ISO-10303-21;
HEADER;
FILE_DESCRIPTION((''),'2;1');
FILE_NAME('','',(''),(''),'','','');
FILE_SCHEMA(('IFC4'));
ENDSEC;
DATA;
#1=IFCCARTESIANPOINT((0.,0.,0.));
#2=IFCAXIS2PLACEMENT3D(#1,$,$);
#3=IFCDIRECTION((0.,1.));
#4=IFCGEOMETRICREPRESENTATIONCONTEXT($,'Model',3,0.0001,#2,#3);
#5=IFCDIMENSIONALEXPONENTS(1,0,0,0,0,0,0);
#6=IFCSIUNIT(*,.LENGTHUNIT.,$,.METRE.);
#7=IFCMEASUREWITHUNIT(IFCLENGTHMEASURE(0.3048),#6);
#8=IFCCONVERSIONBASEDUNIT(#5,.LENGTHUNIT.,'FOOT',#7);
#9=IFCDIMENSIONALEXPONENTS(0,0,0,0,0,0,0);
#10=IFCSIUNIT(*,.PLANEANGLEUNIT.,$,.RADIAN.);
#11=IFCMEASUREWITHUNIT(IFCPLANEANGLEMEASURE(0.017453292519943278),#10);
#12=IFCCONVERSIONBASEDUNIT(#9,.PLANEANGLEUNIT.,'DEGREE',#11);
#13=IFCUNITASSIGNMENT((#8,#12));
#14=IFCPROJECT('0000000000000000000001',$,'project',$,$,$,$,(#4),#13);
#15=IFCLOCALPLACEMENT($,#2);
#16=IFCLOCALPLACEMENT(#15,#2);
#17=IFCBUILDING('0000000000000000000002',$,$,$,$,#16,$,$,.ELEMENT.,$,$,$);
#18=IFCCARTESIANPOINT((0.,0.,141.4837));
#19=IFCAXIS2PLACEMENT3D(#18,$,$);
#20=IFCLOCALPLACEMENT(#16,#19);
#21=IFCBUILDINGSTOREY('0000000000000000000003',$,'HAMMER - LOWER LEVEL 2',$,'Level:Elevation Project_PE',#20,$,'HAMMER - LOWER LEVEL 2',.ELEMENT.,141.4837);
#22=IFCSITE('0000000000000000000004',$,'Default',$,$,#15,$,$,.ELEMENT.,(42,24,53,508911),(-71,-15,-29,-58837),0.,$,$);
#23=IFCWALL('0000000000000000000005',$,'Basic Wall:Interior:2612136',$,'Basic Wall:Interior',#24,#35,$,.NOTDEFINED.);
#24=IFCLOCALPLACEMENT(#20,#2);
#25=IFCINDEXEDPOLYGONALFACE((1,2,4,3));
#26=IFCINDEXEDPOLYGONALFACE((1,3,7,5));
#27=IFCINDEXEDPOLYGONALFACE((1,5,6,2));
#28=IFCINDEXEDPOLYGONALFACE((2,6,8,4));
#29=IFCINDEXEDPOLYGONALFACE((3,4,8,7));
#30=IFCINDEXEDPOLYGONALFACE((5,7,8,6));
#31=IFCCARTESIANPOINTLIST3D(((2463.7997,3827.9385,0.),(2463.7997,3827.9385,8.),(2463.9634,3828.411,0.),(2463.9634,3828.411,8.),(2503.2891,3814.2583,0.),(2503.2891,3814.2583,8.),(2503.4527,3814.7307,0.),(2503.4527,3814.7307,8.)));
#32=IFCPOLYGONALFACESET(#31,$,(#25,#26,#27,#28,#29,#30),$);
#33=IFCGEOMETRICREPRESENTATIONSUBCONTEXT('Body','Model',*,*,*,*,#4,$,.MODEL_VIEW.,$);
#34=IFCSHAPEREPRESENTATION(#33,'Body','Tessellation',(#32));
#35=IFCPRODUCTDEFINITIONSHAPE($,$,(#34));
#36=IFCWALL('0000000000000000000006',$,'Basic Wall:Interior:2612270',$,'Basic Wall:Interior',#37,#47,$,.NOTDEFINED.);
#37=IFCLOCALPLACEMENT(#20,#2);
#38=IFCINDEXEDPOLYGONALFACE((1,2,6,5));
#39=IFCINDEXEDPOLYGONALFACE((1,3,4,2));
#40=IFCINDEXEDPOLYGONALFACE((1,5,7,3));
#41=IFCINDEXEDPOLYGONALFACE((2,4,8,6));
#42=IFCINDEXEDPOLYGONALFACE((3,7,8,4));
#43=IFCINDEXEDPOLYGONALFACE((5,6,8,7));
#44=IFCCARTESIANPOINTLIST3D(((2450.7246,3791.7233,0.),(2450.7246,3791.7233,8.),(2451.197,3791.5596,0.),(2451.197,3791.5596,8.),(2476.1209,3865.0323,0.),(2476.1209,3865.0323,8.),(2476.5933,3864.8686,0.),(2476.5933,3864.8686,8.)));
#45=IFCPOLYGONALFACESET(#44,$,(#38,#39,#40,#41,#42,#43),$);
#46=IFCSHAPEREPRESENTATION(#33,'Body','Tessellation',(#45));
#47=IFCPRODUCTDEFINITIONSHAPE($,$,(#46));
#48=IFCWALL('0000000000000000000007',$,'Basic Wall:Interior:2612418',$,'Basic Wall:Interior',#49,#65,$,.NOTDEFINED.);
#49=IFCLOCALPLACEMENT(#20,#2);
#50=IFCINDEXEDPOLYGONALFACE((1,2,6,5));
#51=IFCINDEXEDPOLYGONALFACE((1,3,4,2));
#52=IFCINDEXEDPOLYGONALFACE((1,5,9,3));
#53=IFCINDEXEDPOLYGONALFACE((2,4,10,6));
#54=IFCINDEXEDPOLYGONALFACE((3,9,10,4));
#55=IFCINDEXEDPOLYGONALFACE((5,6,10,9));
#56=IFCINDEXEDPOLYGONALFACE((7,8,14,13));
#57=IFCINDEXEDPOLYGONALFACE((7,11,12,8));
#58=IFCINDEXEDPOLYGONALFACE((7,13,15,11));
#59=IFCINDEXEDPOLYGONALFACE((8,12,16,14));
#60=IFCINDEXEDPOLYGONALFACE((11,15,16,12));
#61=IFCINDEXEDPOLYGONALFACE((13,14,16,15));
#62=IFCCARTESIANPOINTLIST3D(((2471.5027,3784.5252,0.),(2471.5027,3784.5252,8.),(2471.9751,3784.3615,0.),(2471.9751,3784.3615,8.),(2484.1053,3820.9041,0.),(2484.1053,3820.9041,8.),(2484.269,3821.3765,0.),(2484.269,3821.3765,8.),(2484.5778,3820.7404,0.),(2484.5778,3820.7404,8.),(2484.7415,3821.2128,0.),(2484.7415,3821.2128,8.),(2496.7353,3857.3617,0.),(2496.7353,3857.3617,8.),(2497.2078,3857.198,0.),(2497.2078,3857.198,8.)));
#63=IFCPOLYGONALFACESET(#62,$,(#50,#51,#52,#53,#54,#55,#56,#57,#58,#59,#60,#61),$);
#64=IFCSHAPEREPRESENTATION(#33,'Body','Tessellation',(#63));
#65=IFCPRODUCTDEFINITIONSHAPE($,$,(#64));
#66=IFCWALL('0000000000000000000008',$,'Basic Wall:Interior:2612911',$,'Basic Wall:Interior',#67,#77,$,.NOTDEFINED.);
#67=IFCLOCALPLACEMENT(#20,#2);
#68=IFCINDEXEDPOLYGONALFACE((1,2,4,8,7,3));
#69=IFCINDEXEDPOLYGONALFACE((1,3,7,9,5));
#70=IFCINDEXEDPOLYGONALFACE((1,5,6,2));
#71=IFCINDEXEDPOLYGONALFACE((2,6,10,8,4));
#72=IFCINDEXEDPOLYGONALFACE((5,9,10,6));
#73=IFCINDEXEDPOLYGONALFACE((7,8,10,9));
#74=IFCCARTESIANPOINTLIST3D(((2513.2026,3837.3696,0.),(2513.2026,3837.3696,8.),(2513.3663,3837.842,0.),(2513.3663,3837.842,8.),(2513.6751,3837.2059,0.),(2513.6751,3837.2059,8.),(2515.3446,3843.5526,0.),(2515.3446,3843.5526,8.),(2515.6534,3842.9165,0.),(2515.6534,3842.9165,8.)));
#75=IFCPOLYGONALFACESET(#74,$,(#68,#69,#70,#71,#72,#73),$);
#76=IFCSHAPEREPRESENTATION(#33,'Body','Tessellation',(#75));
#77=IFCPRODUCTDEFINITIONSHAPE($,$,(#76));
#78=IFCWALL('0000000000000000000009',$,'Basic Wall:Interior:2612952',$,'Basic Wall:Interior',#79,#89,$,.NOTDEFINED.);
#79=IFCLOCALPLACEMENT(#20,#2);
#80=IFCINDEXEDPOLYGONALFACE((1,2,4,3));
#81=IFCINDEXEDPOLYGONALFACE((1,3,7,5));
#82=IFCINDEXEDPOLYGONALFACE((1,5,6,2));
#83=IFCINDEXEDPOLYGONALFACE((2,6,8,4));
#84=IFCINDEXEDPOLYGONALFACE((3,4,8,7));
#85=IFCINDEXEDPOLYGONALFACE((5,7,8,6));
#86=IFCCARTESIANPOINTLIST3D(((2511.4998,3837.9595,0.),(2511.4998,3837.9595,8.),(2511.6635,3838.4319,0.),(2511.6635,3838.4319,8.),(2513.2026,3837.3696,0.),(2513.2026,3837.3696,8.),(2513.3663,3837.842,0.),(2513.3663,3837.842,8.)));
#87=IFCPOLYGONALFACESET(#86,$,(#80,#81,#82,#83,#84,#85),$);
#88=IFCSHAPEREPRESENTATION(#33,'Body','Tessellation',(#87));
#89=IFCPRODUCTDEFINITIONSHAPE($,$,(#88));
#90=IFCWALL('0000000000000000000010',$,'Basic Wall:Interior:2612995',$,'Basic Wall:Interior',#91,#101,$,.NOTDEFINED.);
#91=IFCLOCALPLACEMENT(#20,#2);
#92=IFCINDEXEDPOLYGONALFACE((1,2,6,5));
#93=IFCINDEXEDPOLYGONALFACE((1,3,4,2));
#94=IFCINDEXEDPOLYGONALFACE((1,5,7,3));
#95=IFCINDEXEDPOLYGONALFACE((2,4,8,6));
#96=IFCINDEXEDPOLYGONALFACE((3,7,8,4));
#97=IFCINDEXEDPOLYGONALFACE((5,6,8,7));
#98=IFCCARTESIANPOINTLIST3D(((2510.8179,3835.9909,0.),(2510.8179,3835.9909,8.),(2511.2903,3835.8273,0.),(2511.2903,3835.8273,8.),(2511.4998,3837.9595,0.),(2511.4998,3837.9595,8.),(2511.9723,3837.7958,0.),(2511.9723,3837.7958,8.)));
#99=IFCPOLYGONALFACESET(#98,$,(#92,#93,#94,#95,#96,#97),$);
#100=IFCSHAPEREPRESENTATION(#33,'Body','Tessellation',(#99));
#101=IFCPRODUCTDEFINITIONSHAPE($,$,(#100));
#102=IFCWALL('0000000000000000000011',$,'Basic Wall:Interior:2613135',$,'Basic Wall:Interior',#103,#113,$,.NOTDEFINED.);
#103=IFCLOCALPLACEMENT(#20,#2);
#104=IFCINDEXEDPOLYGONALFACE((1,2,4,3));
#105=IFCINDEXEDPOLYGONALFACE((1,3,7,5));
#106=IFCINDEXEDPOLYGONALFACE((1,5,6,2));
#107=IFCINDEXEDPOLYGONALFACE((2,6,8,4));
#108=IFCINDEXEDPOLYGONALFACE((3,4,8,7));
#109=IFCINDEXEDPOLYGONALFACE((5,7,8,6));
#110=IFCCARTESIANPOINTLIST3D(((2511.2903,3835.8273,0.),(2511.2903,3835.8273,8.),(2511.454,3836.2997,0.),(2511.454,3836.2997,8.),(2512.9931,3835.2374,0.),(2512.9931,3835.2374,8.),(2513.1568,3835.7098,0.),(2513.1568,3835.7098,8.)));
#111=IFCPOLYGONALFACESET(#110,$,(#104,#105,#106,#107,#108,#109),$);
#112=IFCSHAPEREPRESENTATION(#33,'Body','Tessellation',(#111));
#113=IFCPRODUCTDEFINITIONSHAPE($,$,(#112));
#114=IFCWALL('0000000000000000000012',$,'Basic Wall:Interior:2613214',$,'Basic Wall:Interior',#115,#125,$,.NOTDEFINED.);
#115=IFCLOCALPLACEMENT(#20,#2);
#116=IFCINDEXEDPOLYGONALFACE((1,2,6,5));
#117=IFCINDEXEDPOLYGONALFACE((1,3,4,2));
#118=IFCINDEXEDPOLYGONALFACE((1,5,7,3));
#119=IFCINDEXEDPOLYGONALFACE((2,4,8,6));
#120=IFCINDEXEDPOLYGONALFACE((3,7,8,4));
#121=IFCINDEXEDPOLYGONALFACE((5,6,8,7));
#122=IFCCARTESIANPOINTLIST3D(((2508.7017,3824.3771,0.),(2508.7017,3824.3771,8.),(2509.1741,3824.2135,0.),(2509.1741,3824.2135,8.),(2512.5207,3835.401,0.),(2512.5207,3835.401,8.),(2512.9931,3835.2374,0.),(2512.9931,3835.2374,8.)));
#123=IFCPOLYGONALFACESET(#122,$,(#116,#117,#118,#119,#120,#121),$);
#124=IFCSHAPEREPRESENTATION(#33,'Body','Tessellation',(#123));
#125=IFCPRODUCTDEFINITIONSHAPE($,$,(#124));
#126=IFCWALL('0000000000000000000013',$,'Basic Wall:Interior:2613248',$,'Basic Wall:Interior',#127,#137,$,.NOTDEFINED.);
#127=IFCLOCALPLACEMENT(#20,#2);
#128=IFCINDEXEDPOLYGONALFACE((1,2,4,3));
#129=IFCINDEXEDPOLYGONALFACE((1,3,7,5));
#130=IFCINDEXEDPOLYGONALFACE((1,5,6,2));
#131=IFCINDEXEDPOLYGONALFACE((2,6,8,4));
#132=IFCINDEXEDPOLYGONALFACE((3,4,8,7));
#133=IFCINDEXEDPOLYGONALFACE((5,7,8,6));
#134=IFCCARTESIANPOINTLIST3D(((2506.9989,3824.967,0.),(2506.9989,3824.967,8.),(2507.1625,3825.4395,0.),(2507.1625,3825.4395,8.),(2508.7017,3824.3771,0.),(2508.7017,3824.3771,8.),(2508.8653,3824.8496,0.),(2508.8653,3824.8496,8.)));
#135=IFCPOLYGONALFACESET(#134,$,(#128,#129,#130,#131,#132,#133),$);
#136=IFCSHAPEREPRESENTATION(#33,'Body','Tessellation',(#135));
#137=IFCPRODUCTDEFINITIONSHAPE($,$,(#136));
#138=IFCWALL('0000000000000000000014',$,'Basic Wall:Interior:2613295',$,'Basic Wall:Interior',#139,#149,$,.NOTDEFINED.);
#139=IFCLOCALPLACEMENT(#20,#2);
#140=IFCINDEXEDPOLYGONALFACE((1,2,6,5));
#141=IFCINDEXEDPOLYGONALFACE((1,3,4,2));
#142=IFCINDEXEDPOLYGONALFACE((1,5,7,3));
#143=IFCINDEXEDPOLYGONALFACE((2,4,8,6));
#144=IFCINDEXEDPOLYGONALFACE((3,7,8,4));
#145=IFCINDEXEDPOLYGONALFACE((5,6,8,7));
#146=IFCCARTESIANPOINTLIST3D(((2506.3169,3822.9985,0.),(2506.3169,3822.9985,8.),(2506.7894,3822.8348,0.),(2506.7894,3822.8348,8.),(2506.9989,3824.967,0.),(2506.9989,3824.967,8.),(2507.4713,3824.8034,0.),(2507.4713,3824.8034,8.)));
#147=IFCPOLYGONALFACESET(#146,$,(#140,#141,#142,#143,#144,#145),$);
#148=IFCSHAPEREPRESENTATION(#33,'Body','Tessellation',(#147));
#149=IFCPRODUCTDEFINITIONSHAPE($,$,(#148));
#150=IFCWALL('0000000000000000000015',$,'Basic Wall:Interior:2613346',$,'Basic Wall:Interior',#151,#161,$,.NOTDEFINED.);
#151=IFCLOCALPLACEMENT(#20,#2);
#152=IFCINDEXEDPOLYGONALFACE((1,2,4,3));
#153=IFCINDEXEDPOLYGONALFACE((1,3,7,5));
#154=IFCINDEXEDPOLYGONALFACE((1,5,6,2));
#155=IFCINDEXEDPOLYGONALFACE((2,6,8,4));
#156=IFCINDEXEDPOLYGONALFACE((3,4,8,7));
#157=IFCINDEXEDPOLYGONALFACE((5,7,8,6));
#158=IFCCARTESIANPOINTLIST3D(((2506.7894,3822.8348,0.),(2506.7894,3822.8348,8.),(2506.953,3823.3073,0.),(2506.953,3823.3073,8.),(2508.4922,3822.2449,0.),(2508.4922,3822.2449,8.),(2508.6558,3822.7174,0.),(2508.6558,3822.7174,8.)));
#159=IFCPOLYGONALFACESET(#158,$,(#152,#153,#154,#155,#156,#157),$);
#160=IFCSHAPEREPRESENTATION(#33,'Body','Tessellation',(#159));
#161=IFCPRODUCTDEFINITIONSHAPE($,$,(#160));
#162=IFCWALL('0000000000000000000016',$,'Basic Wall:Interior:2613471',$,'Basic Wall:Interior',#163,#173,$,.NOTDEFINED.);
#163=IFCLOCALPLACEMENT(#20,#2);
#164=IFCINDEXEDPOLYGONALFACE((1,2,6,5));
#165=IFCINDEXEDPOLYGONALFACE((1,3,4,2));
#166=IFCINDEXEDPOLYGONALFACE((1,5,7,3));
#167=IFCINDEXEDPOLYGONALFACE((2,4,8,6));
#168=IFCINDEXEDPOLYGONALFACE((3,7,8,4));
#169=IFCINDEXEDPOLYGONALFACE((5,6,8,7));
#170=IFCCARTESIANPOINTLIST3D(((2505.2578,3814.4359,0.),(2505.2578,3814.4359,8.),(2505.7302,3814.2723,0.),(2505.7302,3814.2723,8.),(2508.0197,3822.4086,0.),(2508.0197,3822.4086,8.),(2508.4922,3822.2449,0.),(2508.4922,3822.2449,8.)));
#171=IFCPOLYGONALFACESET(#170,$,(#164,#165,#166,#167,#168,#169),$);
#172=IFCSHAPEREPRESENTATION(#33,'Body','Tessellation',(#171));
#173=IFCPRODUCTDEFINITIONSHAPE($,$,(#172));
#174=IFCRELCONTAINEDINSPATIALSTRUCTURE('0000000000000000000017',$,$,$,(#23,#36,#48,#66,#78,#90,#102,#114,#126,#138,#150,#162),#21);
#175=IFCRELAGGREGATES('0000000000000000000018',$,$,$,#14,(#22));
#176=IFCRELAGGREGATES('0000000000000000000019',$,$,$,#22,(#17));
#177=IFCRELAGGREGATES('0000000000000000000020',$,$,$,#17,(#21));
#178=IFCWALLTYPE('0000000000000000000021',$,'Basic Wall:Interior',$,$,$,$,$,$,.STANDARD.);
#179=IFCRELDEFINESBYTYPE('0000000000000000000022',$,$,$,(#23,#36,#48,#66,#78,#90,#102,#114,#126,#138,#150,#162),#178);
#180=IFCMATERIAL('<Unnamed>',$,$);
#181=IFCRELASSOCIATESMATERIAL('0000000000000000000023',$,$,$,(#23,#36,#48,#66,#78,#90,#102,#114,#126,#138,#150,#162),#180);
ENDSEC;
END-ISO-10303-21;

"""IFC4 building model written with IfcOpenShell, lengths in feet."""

from ifc_helpers import new_model, entity, si_unit, converted_unit, direction, frame, origin, place, context, subcontext, project, spatial, indexed_curve, outline, extrude, material, type_object, element, save


model = new_model("IFC4")

# Units and contexts
model_context = context("Model", 3, precision=0.0001, world=origin(), true_north=direction((0.0, 1.0)))
body_context = subcontext(model_context, "Body", "Model", "MODEL_VIEW")
ifc_project = project(units=[converted_unit("LENGTHUNIT", "FOOT", entity("IfcLengthMeasure", 0.3048), si_unit("LENGTHUNIT", "METRE"), dimensions=[1, 0, 0, 0, 0, 0, 0]), converted_unit("PLANEANGLEUNIT", "DEGREE", entity("IfcPlaneAngleMeasure", 0.017453292519943278), si_unit("PLANEANGLEUNIT", "RADIAN"), dimensions=[0, 0, 0, 0, 0, 0, 0])], contexts=[model_context])

# Site, building, storey
site_placement = place(None, origin())
site = spatial("IfcSite", under=ifc_project, at=site_placement, Name="Default", CompositionType="ELEMENT", RefLatitude=(42, 24, 53, 508911), RefLongitude=(-71, -15, -29, -58837), RefElevation=0.0)
building_placement = place(site_placement, origin())
building = spatial("IfcBuilding", under=site, at=building_placement, CompositionType="ELEMENT")
storey_placement = place(building_placement, frame((0.0, 0.0, 141.4837)))
storey = spatial("IfcBuildingStorey", under=building, at=storey_placement, Name="HAMMER - LOWER LEVEL 2", ObjectType="Level:Elevation Project_PE", LongName="HAMMER - LOWER LEVEL 2", CompositionType="ELEMENT", Elevation=141.4837)

# Walls
ifc_material_1 = material(Name="<Unnamed>")
wall_type = type_object("IfcWallType", Name="Basic Wall:Interior", PredefinedType="STANDARD")
wall_1_placement = place(storey_placement, frame((2503.3709, 3814.4945, 0.0), z_axis=(0.0, 0.0, 1.0), x_axis=(-0.944906, 0.327342, 0.0)))
element("IfcWall", 1, at=wall_1_placement, inside=storey, type_object=wall_type, material=ifc_material_1, Name="Basic Wall:Interior:2612136", ObjectType="Basic Wall:Interior", PredefinedType="NOTDEFINED", context=body_context, shape_type="SweptSolid", body=[
    extrude(outline(indexed_curve([(41.7918, 0.25), (0.0, 0.25), (0.0, -0.25), (41.7918, -0.25), (41.7918, 0.25)], self_intersect=False)), origin(), (0.0, 0.0, 1.0), 8.0),
])
wall_2_placement = place(storey_placement, frame((2450.9608, 3791.6415, 0.0), z_axis=(0.0, 0.0, 1.0), x_axis=(0.327342, 0.944906, 0.0)))
element("IfcWall", 2, at=wall_2_placement, inside=storey, type_object=wall_type, material=ifc_material_1, Name="Basic Wall:Interior:2612270", ObjectType="Basic Wall:Interior", PredefinedType="NOTDEFINED", context=body_context, shape_type="SweptSolid", body=[
    extrude(outline(indexed_curve([(77.5833, 0.25), (0.0, 0.25), (0.0, -0.25), (77.5833, -0.25), (77.5833, 0.25)], self_intersect=False)), origin(), (0.0, 0.0, 1.0), 8.0),
])

# Wall, opening
wall_3_placement = place(storey_placement, frame((2496.9715, 3857.2798, 0.0), z_axis=(0.0, 0.0, 1.0), x_axis=(-0.327342, -0.944906, 0.0)))
wall_3 = element("IfcWall", 3, at=wall_3_placement, inside=storey, type_object=wall_type, material=ifc_material_1, Name="Basic Wall:Interior:2612418", ObjectType="Basic Wall:Interior", PredefinedType="NOTDEFINED", context=body_context, shape_type="SweptSolid", body=[
    extrude(outline(indexed_curve([(77.0833, 0.25), (0.0, 0.25), (0.0, -0.25), (77.0833, -0.25), (77.0833, 0.25)], self_intersect=False)), origin(), (0.0, 0.0, 1.0), 8.0),
])
opening_placement = place(storey_placement, frame((2496.9715, 3857.2798, 0.0), z_axis=(0.0, 0.0, 1.0), x_axis=(-0.327342, -0.944906, 0.0)))
element("IfcOpeningElement", 4, at=opening_placement, cuts=wall_3, PredefinedType="OPENING", context=body_context, shape_type="SweptSolid", body=[
    extrude(outline(indexed_curve([(-4.0, -0.25), (4.0, -0.25), (4.0, 0.25), (-4.0, 0.25), (-4.0, -0.25)], self_intersect=False)), frame((38.5833, 0.0, 4.0), z_axis=(-1.0, 0.0, 0.0), x_axis=(0.0, 0.0, 1.0)), (0.0, 0.0, 1.0), 0.5),
])

# Walls
wall_4_placement = place(storey_placement, frame((2515.5808, 3843.4708, 0.0), z_axis=(0.0, 0.0, 1.0), x_axis=(-0.327342, -0.944906, 0.0)))
element("IfcWall", 5, at=wall_4_placement, inside=storey, type_object=wall_type, material=ifc_material_1, Name="Basic Wall:Interior:2612911", ObjectType="Basic Wall:Interior", PredefinedType="NOTDEFINED", context=body_context, shape_type="SweptSolid", body=[
    extrude(outline(indexed_curve([(6.5435, -0.25), (6.5435, 0.25), (0.5, 0.25), (0.0, -0.25), (6.0435, -0.25), (6.5435, -0.25)], self_intersect=False)), origin(), (0.0, 0.0, 1.0), 8.0),
])
wall_5_placement = place(storey_placement, frame((2513.2845, 3837.6058, 0.0), z_axis=(0.0, 0.0, 1.0), x_axis=(-0.944906, 0.327342, 0.0)))
element("IfcWall", 6, at=wall_5_placement, inside=storey, type_object=wall_type, material=ifc_material_1, Name="Basic Wall:Interior:2612952", ObjectType="Basic Wall:Interior", PredefinedType="NOTDEFINED", context=body_context, shape_type="SweptSolid", body=[
    extrude(outline(indexed_curve([(1.8021, 0.25), (0.0, 0.25), (0.0, -0.25), (1.8021, -0.25), (1.8021, 0.25)], self_intersect=False)), origin(), (0.0, 0.0, 1.0), 8.0),
])
wall_6_placement = place(storey_placement, frame((2511.7361, 3837.8776, 0.0), z_axis=(0.0, 0.0, 1.0), x_axis=(-0.327342, -0.944906, 0.0)))
element("IfcWall", 7, at=wall_6_placement, inside=storey, type_object=wall_type, material=ifc_material_1, Name="Basic Wall:Interior:2612995", ObjectType="Basic Wall:Interior", PredefinedType="NOTDEFINED", context=body_context, shape_type="SweptSolid", body=[
    extrude(outline(indexed_curve([(2.0833, 0.25), (0.0, 0.25), (0.0, -0.25), (2.0833, -0.25), (2.0833, 0.25)], self_intersect=False)), origin(), (0.0, 0.0, 1.0), 8.0),
])
wall_7_placement = place(storey_placement, frame((2511.3722, 3836.0635, 0.0), z_axis=(0.0, 0.0, 1.0), x_axis=(0.944906, -0.327342, 0.0)))
element("IfcWall", 8, at=wall_7_placement, inside=storey, type_object=wall_type, material=ifc_material_1, Name="Basic Wall:Interior:2613135", ObjectType="Basic Wall:Interior", PredefinedType="NOTDEFINED", context=body_context, shape_type="SweptSolid", body=[
    extrude(outline(indexed_curve([(1.8021, 0.25), (0.0, 0.25), (0.0, -0.25), (1.8021, -0.25), (1.8021, 0.25)], self_intersect=False)), origin(), (0.0, 0.0, 1.0), 8.0),
])
wall_8_placement = place(storey_placement, frame((2512.7569, 3835.3192, 0.0), z_axis=(0.0, 0.0, 1.0), x_axis=(-0.327342, -0.944906, 0.0)))
element("IfcWall", 9, at=wall_8_placement, inside=storey, type_object=wall_type, material=ifc_material_1, Name="Basic Wall:Interior:2613214", ObjectType="Basic Wall:Interior", PredefinedType="NOTDEFINED", context=body_context, shape_type="SweptSolid", body=[
    extrude(outline(indexed_curve([(11.6667, 0.25), (0.0, 0.25), (0.0, -0.25), (11.6667, -0.25), (11.6667, 0.25)], self_intersect=False)), origin(), (0.0, 0.0, 1.0), 8.0),
])
wall_9_placement = place(storey_placement, frame((2508.7835, 3824.6134, 0.0), z_axis=(0.0, 0.0, 1.0), x_axis=(-0.944906, 0.327342, 0.0)))
element("IfcWall", 10, at=wall_9_placement, inside=storey, type_object=wall_type, material=ifc_material_1, Name="Basic Wall:Interior:2613248", ObjectType="Basic Wall:Interior", PredefinedType="NOTDEFINED", context=body_context, shape_type="SweptSolid", body=[
    extrude(outline(indexed_curve([(1.8021, 0.25), (0.0, 0.25), (0.0, -0.25), (1.8021, -0.25), (1.8021, 0.25)], self_intersect=False)), origin(), (0.0, 0.0, 1.0), 8.0),
])
wall_10_placement = place(storey_placement, frame((2507.2351, 3824.8852, 0.0), z_axis=(0.0, 0.0, 1.0), x_axis=(-0.327342, -0.944906, 0.0)))
element("IfcWall", 11, at=wall_10_placement, inside=storey, type_object=wall_type, material=ifc_material_1, Name="Basic Wall:Interior:2613295", ObjectType="Basic Wall:Interior", PredefinedType="NOTDEFINED", context=body_context, shape_type="SweptSolid", body=[
    extrude(outline(indexed_curve([(2.0833, 0.25), (0.0, 0.25), (0.0, -0.25), (2.0833, -0.25), (2.0833, 0.25)], self_intersect=False)), origin(), (0.0, 0.0, 1.0), 8.0),
])
wall_11_placement = place(storey_placement, frame((2506.8712, 3823.071, 0.0), z_axis=(0.0, 0.0, 1.0), x_axis=(0.944906, -0.327342, 0.0)))
element("IfcWall", 12, at=wall_11_placement, inside=storey, type_object=wall_type, material=ifc_material_1, Name="Basic Wall:Interior:2613346", ObjectType="Basic Wall:Interior", PredefinedType="NOTDEFINED", context=body_context, shape_type="SweptSolid", body=[
    extrude(outline(indexed_curve([(1.8021, 0.25), (0.0, 0.25), (0.0, -0.25), (1.8021, -0.25), (1.8021, 0.25)], self_intersect=False)), origin(), (0.0, 0.0, 1.0), 8.0),
])
wall_12_placement = place(storey_placement, frame((2508.2559, 3822.3267, 0.0), z_axis=(0.0, 0.0, 1.0), x_axis=(-0.327342, -0.944906, 0.0)))
element("IfcWall", 13, at=wall_12_placement, inside=storey, type_object=wall_type, material=ifc_material_1, Name="Basic Wall:Interior:2613471", ObjectType="Basic Wall:Interior", PredefinedType="NOTDEFINED", context=body_context, shape_type="SweptSolid", body=[
    extrude(outline(indexed_curve([(8.4375, 0.25), (0.0, 0.25), (0.0, -0.25), (8.4375, -0.25), (8.4375, 0.25)], self_intersect=False)), origin(), (0.0, 0.0, 1.0), 8.0),
])

save(model, "model.ifc")
